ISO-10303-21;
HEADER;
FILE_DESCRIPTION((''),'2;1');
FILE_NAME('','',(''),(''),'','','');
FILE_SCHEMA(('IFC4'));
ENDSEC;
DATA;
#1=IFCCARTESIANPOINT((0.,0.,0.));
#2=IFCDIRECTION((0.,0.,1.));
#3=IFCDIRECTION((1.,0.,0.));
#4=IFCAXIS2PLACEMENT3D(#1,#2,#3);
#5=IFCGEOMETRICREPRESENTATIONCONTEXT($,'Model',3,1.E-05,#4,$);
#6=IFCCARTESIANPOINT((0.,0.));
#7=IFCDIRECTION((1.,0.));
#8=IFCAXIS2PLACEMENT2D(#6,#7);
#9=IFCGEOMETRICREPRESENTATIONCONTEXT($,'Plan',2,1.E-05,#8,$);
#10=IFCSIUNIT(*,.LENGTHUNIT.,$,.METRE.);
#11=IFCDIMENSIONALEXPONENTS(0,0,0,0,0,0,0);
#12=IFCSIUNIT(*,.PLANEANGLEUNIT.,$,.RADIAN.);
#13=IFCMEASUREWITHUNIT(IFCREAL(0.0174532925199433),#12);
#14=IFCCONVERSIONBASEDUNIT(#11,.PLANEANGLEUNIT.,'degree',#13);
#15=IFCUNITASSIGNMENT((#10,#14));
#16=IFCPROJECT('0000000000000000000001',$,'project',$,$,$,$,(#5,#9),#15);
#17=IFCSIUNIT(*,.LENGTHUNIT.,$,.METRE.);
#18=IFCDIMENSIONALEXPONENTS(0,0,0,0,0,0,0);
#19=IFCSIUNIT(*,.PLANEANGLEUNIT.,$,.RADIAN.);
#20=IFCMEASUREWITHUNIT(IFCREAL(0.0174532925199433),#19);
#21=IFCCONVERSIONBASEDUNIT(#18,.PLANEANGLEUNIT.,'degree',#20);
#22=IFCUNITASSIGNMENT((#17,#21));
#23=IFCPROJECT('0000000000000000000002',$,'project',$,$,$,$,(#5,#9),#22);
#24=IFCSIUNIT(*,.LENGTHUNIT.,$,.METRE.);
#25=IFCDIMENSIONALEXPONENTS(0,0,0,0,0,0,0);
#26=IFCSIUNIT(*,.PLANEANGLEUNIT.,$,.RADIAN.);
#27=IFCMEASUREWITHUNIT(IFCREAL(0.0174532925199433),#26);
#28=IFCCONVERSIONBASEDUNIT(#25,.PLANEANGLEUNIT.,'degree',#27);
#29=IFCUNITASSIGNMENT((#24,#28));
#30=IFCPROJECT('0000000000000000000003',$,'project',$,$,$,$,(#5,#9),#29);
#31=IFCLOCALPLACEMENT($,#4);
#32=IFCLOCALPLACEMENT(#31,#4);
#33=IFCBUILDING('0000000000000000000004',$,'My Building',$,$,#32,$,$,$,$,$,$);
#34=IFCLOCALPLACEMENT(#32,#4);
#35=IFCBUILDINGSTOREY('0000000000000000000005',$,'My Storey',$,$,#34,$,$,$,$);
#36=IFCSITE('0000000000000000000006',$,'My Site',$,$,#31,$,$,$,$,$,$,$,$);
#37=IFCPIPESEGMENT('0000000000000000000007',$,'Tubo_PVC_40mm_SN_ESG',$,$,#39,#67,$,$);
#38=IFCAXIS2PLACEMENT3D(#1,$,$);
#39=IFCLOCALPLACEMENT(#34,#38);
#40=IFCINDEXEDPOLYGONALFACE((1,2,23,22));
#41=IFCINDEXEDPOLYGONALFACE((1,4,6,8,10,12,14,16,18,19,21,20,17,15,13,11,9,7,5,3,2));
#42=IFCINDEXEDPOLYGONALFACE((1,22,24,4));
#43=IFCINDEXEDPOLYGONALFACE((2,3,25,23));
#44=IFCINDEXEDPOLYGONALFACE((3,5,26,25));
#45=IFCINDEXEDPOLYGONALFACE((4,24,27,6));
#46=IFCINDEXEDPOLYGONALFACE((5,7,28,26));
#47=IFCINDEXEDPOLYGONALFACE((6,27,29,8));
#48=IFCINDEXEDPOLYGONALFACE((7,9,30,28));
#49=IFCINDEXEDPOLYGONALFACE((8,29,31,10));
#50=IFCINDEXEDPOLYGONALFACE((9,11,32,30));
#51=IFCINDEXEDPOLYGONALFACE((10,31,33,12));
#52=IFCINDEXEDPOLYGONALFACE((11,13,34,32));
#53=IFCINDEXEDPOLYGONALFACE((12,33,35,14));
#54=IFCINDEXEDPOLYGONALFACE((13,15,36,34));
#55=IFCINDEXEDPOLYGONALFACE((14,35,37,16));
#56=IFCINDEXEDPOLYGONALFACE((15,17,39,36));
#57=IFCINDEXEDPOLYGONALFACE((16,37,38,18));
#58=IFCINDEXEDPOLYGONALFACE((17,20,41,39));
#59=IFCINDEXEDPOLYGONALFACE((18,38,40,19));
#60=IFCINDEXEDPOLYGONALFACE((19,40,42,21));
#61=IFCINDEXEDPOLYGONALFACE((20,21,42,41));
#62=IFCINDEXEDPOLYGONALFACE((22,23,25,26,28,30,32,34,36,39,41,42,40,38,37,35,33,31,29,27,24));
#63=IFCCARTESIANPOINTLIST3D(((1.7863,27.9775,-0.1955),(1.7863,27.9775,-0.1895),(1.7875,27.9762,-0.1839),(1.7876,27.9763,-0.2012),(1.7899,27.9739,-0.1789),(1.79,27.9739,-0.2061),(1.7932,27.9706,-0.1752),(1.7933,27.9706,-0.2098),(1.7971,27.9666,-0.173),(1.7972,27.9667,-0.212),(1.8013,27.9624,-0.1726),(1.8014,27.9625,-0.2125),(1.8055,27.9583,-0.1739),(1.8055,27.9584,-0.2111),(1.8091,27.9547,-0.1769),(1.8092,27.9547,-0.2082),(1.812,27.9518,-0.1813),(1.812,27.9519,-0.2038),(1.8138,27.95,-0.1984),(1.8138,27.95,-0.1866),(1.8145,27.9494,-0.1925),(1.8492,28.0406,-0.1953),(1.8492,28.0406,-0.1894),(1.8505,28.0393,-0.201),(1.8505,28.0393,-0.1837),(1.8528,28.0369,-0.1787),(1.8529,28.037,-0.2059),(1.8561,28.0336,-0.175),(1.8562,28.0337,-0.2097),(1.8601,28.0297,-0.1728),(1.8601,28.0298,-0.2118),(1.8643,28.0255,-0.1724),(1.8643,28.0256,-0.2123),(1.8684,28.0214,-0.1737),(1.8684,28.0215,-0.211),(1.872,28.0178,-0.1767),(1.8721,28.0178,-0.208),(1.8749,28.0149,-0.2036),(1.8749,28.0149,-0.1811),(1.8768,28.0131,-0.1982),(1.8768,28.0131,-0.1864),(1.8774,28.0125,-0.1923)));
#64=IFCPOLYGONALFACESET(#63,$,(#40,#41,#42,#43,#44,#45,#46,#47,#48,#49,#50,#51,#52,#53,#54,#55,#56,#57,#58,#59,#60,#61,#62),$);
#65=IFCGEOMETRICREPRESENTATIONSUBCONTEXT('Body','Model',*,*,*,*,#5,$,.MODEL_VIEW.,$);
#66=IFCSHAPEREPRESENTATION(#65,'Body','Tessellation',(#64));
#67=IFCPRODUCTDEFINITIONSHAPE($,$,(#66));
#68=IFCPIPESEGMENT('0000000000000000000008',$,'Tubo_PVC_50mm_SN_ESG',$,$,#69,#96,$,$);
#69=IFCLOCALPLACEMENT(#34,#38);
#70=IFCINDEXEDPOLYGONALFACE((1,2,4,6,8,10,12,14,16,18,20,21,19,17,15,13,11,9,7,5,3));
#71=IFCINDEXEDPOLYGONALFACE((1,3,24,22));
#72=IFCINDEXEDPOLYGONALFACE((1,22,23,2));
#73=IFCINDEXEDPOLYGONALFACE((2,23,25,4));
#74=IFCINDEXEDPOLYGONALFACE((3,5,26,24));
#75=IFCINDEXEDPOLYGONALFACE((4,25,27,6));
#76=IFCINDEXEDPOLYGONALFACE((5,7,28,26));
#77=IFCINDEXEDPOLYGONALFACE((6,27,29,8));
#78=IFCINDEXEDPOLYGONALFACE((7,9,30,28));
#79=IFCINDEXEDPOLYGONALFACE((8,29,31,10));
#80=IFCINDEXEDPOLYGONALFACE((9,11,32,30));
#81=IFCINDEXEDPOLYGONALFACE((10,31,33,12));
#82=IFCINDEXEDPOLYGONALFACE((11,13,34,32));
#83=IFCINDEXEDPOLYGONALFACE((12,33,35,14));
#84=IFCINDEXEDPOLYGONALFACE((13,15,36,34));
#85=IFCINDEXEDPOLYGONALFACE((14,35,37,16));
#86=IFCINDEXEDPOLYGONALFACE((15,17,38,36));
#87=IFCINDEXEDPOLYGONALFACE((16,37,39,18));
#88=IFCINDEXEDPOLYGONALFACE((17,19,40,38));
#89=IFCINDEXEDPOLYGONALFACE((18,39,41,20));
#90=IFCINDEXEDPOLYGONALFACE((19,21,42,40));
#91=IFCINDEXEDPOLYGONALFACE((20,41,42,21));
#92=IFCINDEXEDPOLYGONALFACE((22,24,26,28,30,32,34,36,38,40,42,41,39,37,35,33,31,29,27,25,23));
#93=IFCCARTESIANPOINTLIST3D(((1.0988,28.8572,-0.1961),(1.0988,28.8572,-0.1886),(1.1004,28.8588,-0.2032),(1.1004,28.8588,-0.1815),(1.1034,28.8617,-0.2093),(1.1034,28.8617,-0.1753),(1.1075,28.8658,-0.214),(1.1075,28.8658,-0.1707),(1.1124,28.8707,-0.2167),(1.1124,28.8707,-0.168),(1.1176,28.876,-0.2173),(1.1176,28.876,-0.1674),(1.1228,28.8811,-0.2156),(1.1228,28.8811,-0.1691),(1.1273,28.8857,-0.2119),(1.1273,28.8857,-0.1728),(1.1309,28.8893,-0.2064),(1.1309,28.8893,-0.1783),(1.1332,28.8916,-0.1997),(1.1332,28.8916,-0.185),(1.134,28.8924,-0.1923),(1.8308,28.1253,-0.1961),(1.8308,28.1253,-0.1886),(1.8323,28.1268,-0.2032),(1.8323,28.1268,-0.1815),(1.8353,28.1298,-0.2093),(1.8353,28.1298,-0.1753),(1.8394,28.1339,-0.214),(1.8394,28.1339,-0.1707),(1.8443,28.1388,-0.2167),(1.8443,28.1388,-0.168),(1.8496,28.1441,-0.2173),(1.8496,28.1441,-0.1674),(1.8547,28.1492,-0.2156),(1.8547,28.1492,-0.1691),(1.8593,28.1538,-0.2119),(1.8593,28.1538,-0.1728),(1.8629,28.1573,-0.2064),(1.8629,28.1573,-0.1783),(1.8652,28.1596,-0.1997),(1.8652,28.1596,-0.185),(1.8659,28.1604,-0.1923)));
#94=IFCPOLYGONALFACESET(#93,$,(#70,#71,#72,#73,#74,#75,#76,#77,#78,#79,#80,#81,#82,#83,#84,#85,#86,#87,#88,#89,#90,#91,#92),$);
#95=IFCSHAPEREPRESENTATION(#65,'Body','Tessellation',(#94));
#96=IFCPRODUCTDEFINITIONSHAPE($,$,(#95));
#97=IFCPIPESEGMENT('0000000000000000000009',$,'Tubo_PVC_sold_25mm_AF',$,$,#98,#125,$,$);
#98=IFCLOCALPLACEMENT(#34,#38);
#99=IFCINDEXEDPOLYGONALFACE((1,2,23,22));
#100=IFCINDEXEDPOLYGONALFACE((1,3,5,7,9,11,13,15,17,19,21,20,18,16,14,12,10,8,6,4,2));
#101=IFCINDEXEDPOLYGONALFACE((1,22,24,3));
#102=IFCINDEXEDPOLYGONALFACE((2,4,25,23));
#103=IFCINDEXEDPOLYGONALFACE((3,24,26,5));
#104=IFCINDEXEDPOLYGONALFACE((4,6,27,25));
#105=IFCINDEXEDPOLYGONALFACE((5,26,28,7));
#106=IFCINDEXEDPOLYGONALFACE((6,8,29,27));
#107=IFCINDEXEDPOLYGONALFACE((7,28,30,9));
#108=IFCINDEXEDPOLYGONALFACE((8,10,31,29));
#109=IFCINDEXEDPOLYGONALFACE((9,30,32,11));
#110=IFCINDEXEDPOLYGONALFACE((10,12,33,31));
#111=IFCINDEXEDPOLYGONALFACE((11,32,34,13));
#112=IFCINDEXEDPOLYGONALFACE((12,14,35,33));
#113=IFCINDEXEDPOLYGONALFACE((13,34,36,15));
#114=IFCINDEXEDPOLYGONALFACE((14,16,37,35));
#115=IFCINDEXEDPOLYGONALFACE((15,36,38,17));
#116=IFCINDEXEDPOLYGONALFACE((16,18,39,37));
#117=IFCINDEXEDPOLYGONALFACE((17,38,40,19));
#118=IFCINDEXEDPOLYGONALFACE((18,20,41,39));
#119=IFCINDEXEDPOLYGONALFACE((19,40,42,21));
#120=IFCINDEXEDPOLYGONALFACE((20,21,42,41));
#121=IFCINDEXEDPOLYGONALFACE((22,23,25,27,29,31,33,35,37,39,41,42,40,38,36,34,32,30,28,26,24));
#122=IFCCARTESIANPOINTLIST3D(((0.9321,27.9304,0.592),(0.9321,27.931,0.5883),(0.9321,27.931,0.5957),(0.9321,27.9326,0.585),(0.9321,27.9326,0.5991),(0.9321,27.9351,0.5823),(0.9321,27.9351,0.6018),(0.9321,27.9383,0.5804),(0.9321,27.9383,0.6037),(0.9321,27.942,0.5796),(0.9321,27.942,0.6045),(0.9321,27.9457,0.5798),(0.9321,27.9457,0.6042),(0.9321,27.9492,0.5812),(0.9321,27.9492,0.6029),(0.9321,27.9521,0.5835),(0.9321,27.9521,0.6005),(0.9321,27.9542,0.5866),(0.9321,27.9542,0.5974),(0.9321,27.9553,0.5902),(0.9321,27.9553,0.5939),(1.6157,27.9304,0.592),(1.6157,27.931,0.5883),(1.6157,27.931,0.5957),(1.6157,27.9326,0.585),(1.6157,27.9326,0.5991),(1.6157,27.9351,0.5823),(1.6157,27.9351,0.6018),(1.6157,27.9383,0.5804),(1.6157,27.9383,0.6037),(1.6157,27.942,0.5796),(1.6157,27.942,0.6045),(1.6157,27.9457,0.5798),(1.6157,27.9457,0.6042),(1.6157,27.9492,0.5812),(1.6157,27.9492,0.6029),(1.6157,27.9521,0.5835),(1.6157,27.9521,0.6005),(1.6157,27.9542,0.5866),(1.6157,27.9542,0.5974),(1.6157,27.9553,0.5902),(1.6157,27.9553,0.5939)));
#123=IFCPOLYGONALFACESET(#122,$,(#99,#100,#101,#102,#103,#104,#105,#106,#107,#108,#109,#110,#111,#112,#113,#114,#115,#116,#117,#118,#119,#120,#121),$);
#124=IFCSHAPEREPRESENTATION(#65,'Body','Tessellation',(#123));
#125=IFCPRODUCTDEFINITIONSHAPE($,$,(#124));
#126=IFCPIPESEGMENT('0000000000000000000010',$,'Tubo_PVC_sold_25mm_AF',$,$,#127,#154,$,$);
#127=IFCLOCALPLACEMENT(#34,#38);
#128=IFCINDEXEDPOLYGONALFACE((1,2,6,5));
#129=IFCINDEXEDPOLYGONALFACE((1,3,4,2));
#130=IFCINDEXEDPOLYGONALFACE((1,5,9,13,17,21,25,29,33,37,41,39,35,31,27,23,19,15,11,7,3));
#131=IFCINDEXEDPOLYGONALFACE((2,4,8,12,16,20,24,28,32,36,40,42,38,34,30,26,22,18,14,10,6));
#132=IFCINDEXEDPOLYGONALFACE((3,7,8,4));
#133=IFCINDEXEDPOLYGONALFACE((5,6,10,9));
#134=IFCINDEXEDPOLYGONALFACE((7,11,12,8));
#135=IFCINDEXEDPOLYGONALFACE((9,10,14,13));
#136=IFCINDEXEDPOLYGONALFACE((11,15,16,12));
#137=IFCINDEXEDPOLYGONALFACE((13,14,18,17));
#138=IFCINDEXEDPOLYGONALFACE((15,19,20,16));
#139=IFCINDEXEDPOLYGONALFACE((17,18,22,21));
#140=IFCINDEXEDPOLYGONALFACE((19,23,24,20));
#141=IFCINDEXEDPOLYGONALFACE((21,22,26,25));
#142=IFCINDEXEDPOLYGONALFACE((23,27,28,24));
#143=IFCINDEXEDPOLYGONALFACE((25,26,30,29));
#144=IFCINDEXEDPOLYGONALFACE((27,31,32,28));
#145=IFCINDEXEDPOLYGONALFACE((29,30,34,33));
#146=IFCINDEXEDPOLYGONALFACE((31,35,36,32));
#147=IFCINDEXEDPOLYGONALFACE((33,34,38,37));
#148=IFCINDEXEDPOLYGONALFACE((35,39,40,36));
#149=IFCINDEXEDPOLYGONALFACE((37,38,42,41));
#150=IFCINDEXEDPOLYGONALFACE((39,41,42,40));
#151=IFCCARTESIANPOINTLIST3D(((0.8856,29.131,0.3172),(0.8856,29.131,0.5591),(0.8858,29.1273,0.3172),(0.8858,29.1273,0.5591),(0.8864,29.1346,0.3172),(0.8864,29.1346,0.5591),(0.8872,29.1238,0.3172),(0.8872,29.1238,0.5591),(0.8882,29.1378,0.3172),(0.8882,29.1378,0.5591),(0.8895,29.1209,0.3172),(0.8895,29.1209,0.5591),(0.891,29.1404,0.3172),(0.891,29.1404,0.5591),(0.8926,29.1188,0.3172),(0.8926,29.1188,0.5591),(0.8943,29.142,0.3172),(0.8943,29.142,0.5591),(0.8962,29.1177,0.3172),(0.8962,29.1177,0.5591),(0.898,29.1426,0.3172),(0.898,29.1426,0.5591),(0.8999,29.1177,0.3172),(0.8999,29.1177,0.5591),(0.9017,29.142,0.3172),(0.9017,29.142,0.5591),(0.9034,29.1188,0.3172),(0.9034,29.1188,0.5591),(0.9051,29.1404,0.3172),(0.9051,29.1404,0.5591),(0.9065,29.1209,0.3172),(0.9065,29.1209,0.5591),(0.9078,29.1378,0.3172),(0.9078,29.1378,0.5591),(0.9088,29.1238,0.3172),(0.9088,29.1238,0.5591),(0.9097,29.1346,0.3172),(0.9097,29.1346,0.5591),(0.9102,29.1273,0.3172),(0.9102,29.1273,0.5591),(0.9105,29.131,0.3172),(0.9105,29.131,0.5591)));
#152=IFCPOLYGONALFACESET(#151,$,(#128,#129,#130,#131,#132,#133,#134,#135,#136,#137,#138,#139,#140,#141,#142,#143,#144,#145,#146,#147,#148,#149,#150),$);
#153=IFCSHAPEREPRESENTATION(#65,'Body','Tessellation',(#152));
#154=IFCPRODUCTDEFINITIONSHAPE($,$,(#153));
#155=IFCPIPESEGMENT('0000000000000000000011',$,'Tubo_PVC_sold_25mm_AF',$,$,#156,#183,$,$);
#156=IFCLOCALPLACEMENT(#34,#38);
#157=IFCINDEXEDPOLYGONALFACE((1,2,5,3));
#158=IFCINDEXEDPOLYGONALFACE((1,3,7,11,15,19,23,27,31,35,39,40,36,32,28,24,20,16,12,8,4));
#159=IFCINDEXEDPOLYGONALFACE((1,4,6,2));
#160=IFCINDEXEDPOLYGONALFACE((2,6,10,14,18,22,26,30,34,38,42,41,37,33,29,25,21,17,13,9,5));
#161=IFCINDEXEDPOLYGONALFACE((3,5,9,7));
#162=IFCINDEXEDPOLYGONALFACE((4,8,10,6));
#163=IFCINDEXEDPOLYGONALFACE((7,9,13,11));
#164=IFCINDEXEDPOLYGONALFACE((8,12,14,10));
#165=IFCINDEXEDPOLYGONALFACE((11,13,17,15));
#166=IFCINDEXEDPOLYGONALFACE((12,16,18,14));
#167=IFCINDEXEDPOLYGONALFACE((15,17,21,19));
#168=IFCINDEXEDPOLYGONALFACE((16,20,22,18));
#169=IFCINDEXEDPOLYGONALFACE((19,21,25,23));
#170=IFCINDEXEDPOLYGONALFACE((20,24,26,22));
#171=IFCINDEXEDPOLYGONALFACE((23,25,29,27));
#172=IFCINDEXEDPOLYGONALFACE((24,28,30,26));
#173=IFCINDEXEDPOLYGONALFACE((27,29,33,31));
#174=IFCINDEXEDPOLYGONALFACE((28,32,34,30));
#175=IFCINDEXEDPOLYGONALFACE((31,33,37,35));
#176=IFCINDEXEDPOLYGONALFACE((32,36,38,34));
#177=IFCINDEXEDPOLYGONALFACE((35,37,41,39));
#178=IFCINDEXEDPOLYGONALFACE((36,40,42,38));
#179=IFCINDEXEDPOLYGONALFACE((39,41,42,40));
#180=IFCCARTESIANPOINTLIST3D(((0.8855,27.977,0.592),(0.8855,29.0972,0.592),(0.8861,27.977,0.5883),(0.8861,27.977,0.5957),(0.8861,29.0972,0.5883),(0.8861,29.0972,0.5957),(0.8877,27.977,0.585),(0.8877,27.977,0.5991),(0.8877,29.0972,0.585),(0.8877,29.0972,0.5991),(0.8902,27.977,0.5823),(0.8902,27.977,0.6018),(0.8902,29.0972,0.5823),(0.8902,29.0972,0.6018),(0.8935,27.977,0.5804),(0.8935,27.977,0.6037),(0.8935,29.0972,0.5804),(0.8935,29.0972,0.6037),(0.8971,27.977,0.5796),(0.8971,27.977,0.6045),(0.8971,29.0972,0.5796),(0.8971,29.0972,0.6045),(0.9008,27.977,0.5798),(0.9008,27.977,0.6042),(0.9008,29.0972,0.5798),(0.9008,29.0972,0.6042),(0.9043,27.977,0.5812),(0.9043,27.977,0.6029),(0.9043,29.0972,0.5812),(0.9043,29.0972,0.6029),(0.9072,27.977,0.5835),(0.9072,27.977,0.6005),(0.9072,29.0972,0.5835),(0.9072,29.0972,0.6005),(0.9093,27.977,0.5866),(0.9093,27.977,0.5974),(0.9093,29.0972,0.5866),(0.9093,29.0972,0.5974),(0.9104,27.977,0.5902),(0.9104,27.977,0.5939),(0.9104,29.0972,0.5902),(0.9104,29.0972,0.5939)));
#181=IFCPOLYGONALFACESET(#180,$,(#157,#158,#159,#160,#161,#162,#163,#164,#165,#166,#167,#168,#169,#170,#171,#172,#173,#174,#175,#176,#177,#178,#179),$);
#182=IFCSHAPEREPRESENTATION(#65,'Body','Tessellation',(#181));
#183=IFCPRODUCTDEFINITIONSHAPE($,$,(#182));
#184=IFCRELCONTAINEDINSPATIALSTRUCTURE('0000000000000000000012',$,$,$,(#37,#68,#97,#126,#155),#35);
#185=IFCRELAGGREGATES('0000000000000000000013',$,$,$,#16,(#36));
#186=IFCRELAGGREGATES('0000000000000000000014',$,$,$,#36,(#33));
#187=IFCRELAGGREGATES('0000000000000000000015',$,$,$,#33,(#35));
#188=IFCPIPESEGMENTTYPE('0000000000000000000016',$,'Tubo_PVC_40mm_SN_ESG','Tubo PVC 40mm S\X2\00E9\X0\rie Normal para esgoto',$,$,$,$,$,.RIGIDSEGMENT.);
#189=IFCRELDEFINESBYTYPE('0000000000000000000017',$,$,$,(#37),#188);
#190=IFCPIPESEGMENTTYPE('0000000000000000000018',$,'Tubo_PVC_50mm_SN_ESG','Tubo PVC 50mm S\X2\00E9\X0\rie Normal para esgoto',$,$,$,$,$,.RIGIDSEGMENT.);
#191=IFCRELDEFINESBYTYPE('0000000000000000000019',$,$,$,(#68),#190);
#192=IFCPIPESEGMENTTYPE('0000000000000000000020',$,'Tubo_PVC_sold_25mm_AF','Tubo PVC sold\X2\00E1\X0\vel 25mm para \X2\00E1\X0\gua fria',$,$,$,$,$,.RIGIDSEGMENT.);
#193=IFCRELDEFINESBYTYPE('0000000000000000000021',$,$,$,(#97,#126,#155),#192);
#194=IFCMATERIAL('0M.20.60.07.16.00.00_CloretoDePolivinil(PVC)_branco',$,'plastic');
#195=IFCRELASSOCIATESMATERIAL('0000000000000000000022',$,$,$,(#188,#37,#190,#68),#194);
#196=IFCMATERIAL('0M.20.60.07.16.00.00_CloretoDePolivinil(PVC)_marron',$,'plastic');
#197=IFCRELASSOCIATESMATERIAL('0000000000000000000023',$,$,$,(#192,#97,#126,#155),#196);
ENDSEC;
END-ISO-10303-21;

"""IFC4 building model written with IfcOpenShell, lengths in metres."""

from ifc_helpers import new_model, entity, si_unit, converted_unit, frame, origin_with_axes, origin_2d_with_axis, place, context, subcontext, project, spatial, circle, extrude, material, material_profile, profile_set, profile_usage, type_object, element, save


model = new_model("IFC4")

# Units and contexts
model_context = context("Model", 3, precision=1e-05, world=origin_with_axes())
plan_context = context("Plan", 2, precision=1e-05, world=origin_2d_with_axis())
body_context_1 = subcontext(model_context, "Body", "Model", "MODEL_VIEW")
ifc_project_1 = project(units=[si_unit("LENGTHUNIT", "METRE"), converted_unit("PLANEANGLEUNIT", "degree", entity("IfcReal", 0.0174532925199433), si_unit("PLANEANGLEUNIT", "RADIAN"), dimensions=[0, 0, 0, 0, 0, 0, 0])], contexts=[model_context, plan_context])
ifc_project_2 = project(units=[si_unit("LENGTHUNIT", "METRE"), converted_unit("PLANEANGLEUNIT", "degree", entity("IfcReal", 0.0174532925199433), si_unit("PLANEANGLEUNIT", "RADIAN"), dimensions=[0, 0, 0, 0, 0, 0, 0])], contexts=[model_context, plan_context])
ifc_project_3 = project(units=[si_unit("LENGTHUNIT", "METRE"), converted_unit("PLANEANGLEUNIT", "degree", entity("IfcReal", 0.0174532925199433), si_unit("PLANEANGLEUNIT", "RADIAN"), dimensions=[0, 0, 0, 0, 0, 0, 0])], contexts=[model_context, plan_context])

# Site, building, storey
site_placement = place(None, origin_with_axes())
site = spatial("IfcSite", under=ifc_project_1, at=site_placement, Name="My Site")
building_placement = place(site_placement, origin_with_axes())
building = spatial("IfcBuilding", under=site, at=building_placement, Name="My Building")
storey_placement = place(building_placement, origin_with_axes())
storey = spatial("IfcBuildingStorey", under=building, at=storey_placement, Name="My Storey")

# Pipe segments
ifc_material_1 = material(Name="0M.20.60.07.16.00.00_CloretoDePolivinil(PVC)_branco", Category="plastic")
ifc_material_profile_1 = material_profile(ifc_material_1, circle(Radius=0.02))
ifc_profile_set_1 = profile_set([ifc_material_profile_1])
pipe_segment_type_1 = type_object("IfcPipeSegmentType", Name="Tubo_PVC_40mm_SN_ESG", Description="Tubo PVC 40mm Série Normal para esgoto", PredefinedType="RIGIDSEGMENT", material=ifc_profile_set_1)
ifc_profile_usage_1 = profile_usage(ifc_profile_set_1, cardinal=5)
pipe_segment_1_placement = place(storey_placement, frame((1.8632, 28.0266, -0.1923), z_axis=(-0.706297, -0.707912, -0.002118), x_axis=(0.707914, -0.706299, 0.0)))
element("IfcPipeSegment", 1, at=pipe_segment_1_placement, inside=storey, type_object=pipe_segment_type_1, material=ifc_profile_usage_1, Name="Tubo_PVC_40mm_SN_ESG", context=body_context_1, shape_type="SweptSolid", body=[
    extrude(circle(Radius=0.02), origin_with_axes(), (0.0, 0.0, 1.0), 0.0891),
])
ifc_material_profile_2 = material_profile(ifc_material_1, circle(Radius=0.025))
ifc_profile_set_2 = profile_set([ifc_material_profile_2])
ifc_profile_usage_2 = profile_usage(ifc_profile_set_2, cardinal=5)
pipe_segment_type_2 = type_object("IfcPipeSegmentType", Name="Tubo_PVC_50mm_SN_ESG", Description="Tubo PVC 50mm Série Normal para esgoto", PredefinedType="RIGIDSEGMENT", material=ifc_profile_set_2)
pipe_segment_2_placement = place(storey_placement, frame((1.1163, 28.8747, -0.1923), z_axis=(0.707107, -0.707107, 0.0), x_axis=(0.707107, 0.707107, 0.0)))
element("IfcPipeSegment", 2, at=pipe_segment_2_placement, inside=storey, type_object=pipe_segment_type_2, material=ifc_profile_usage_2, Name="Tubo_PVC_50mm_SN_ESG", context=body_context_1, shape_type="SweptSolid", body=[
    extrude(circle(Radius=0.025), origin_with_axes(), (0.0, 0.0, 1.0), 1.0351),
])
ifc_material_2 = material(Name="0M.20.60.07.16.00.00_CloretoDePolivinil(PVC)_marron", Category="plastic")
ifc_material_profile_3 = material_profile(ifc_material_2, circle(Radius=0.0125))
ifc_profile_set_3 = profile_set([ifc_material_profile_3])
ifc_profile_usage_3 = profile_usage(ifc_profile_set_3, cardinal=5)
pipe_segment_type_3 = type_object("IfcPipeSegmentType", Name="Tubo_PVC_sold_25mm_AF", Description="Tubo PVC soldável 25mm para água fria", PredefinedType="RIGIDSEGMENT", material=ifc_profile_set_3)
pipe_segment_3_placement = place(storey_placement, frame((1.6157, 27.9429, 0.592), z_axis=(-1.0, 0.0, 0.0), x_axis=(0.0, -1.0, 0.0)))
element("IfcPipeSegment", 3, at=pipe_segment_3_placement, inside=storey, type_object=pipe_segment_type_3, material=ifc_profile_usage_3, Name="Tubo_PVC_sold_25mm_AF", context=body_context_1, shape_type="SweptSolid", body=[
    extrude(circle(Radius=0.0125), origin_with_axes(), (0.0, 0.0, 1.0), 0.6836),
])
ifc_profile_usage_4 = profile_usage(ifc_profile_set_3, cardinal=5)
pipe_segment_4_placement = place(storey_placement, frame((0.898, 29.1301, 0.3172), z_axis=(0.0, 0.0, 1.0), x_axis=(0.0, 1.0, 0.0)))
element("IfcPipeSegment", 4, at=pipe_segment_4_placement, inside=storey, type_object=pipe_segment_type_3, material=ifc_profile_usage_4, Name="Tubo_PVC_sold_25mm_AF", context=body_context_1, shape_type="SweptSolid", body=[
    extrude(circle(Radius=0.0125), origin_with_axes(), (0.0, 0.0, 1.0), 0.2419),
])
ifc_profile_usage_5 = profile_usage(ifc_profile_set_3, cardinal=5)
pipe_segment_5_placement = place(storey_placement, frame((0.898, 27.977, 0.592), z_axis=(0.0, 1.0, 0.0), x_axis=(-1.0, 0.0, 0.0)))
element("IfcPipeSegment", 5, at=pipe_segment_5_placement, inside=storey, type_object=pipe_segment_type_3, material=ifc_profile_usage_5, Name="Tubo_PVC_sold_25mm_AF", context=body_context_1, shape_type="SweptSolid", body=[
    extrude(circle(Radius=0.0125), origin_with_axes(), (0.0, 0.0, 1.0), 1.1202),
])

save(model, "model.ifc")
